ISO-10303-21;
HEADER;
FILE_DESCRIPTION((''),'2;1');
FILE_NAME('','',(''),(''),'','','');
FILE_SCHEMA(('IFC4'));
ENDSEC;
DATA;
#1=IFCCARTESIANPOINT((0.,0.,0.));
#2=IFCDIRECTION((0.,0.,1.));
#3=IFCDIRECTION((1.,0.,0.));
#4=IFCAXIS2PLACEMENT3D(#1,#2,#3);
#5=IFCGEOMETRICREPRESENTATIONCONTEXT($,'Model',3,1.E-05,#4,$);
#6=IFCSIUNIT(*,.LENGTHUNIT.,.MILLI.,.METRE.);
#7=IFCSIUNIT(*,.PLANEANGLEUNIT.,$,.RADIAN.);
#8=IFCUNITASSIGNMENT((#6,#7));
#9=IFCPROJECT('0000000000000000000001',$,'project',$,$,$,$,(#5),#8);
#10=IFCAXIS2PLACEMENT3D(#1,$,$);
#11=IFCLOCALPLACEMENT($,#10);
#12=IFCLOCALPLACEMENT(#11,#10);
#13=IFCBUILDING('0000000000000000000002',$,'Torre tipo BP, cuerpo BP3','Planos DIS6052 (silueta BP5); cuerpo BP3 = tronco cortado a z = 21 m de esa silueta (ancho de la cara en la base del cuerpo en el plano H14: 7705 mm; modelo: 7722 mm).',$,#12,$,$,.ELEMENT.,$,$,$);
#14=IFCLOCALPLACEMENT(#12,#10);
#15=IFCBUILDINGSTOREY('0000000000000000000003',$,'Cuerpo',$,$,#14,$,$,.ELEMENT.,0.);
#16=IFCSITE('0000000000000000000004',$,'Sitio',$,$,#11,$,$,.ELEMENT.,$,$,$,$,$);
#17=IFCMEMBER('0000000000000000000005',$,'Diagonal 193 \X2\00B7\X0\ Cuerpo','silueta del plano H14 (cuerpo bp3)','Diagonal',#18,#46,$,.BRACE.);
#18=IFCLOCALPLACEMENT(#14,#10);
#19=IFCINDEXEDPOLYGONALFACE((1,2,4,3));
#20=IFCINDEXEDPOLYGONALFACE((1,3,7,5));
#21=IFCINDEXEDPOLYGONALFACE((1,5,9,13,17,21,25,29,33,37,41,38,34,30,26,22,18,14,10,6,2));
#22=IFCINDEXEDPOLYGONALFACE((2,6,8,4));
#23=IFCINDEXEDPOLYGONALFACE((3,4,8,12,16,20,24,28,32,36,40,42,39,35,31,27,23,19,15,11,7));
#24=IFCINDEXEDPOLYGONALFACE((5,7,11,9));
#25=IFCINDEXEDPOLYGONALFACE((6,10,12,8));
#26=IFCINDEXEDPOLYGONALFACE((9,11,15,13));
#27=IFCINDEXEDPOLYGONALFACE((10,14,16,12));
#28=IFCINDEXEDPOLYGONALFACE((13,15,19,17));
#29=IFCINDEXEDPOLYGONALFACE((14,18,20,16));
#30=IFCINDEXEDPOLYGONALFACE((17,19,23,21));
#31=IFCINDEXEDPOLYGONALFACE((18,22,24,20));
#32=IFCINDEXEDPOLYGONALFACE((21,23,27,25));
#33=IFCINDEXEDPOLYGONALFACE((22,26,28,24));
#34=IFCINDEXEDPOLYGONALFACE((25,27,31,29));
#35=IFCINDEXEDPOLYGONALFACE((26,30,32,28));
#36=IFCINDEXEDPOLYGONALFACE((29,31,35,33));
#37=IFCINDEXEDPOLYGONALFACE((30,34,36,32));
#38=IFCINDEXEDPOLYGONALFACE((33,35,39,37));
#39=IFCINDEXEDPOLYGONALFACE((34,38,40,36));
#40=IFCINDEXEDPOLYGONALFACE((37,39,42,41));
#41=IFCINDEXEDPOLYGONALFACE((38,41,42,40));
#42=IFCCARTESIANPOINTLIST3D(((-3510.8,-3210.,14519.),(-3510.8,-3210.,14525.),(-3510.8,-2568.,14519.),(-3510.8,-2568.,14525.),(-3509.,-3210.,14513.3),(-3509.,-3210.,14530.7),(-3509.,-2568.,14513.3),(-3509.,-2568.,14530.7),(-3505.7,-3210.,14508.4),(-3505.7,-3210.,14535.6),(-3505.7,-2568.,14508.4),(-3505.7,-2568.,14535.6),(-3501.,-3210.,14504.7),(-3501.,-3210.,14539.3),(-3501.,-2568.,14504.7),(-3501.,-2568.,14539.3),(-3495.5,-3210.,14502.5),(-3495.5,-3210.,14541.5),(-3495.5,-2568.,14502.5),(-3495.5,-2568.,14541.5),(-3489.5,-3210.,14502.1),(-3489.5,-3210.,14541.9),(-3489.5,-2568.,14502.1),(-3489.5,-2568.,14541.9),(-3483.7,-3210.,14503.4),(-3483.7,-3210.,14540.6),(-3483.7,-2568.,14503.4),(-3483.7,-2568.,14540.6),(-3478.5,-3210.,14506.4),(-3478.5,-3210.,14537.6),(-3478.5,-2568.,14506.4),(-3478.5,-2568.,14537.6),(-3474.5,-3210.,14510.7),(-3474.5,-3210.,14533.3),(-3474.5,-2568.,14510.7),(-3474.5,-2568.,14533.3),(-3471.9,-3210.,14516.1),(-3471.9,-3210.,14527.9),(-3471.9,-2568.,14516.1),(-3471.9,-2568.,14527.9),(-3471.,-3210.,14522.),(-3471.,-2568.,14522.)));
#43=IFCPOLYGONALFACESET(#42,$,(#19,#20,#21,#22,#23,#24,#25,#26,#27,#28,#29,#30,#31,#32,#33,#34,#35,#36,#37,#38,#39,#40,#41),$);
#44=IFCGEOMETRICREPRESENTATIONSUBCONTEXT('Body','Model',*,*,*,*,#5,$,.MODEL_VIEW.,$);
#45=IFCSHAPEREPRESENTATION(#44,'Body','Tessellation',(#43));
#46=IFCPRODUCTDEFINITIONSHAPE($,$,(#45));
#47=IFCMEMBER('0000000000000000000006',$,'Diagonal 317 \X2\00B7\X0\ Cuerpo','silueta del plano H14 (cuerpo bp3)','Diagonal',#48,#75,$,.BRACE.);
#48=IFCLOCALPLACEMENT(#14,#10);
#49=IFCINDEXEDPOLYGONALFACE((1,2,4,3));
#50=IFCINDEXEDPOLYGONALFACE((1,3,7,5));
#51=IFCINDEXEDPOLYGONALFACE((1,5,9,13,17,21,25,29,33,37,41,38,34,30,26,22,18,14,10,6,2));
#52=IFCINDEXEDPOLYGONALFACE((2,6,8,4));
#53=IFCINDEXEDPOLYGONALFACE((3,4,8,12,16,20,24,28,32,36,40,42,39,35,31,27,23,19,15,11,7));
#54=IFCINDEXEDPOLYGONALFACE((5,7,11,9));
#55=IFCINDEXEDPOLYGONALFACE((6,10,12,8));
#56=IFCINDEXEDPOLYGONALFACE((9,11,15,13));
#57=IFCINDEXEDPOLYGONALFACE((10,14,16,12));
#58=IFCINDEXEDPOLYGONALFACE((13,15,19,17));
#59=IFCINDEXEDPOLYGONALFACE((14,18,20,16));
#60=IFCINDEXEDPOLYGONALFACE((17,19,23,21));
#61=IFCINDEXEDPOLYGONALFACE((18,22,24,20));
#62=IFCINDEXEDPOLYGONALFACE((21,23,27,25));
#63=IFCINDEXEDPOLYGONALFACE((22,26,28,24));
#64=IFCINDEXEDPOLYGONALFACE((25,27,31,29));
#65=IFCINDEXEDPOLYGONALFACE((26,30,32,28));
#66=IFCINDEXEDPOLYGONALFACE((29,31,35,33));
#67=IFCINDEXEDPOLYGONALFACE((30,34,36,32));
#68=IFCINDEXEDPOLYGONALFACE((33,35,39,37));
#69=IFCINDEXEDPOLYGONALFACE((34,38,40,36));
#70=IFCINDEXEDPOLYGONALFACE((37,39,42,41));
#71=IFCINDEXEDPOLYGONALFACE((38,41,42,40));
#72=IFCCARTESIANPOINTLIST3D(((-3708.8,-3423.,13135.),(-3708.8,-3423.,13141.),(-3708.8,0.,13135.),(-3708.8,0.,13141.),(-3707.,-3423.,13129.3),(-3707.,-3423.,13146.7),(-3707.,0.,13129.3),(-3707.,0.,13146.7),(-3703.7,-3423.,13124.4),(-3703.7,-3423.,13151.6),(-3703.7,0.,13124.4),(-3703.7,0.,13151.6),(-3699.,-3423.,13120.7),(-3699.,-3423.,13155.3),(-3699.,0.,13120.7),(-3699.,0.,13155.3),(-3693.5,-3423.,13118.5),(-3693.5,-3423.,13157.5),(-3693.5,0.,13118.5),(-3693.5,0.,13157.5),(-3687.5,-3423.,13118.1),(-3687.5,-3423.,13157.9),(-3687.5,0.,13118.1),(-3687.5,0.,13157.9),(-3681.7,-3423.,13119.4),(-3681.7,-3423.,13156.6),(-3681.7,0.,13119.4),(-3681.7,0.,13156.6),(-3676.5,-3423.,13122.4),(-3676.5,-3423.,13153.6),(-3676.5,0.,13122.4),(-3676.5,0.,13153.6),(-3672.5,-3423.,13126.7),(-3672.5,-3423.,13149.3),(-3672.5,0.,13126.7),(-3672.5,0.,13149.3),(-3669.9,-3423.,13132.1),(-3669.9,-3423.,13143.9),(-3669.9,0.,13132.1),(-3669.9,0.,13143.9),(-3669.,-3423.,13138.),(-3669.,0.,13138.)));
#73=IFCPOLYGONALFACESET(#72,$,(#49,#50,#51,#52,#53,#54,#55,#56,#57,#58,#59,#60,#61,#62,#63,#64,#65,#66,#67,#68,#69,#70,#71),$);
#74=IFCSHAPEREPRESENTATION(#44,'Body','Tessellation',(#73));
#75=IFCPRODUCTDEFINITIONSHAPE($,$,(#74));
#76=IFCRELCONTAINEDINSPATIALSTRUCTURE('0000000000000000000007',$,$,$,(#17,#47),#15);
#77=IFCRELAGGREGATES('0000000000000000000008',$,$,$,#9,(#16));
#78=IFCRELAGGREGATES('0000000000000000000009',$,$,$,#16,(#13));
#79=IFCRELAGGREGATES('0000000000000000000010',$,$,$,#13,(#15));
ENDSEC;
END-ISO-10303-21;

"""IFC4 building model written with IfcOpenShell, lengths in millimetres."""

from ifc_helpers import new_model, si_unit, frame, origin, origin_with_axes, place, context, subcontext, project, spatial, circle, extrude, element, save


model = new_model("IFC4")

# Units and contexts
model_context = context("Model", 3, precision=1e-05, world=origin_with_axes())
body_context = subcontext(model_context, "Body", "Model", "MODEL_VIEW")
ifc_project = project(units=[si_unit("LENGTHUNIT", "METRE", prefix="MILLI"), si_unit("PLANEANGLEUNIT", "RADIAN")], contexts=[model_context])

# Site, building, storey
site_placement = place(None, origin())
site = spatial("IfcSite", under=ifc_project, at=site_placement, Name="Sitio", CompositionType="ELEMENT")
building_placement = place(site_placement, origin())
building = spatial("IfcBuilding", under=site, at=building_placement, Name="Torre tipo BP, cuerpo BP3", Description="Planos DIS6052 (silueta BP5); cuerpo BP3 = tronco cortado a z = 21 m de esa silueta (ancho de la cara en la base del cuerpo en el plano H14: 7705 mm; modelo: 7722 mm).", CompositionType="ELEMENT")
storey_placement = place(building_placement, origin())
storey = spatial("IfcBuildingStorey", under=building, at=storey_placement, Name="Cuerpo", CompositionType="ELEMENT", Elevation=0.0)

# Members
member_1_placement = place(storey_placement, frame((-3491.0, -2568.0, 14522.0), z_axis=(0.0, -1.0, 0.0), x_axis=(1.0, 0.0, 0.0)))
element("IfcMember", 1, at=member_1_placement, inside=storey, Name="Diagonal 193 · Cuerpo", Description="silueta del plano H14 (cuerpo bp3)", ObjectType="Diagonal", PredefinedType="BRACE", context=body_context, shape_type="SweptSolid", body=[
    extrude(circle(Radius=20.0), None, (0.0, 0.0, 1.0), 642.0),
])
member_2_placement = place(storey_placement, frame((-3689.0, -3423.0, 13138.0), z_axis=(0.0, 1.0, 0.0), x_axis=(1.0, 0.0, 0.0)))
element("IfcMember", 2, at=member_2_placement, inside=storey, Name="Diagonal 317 · Cuerpo", Description="silueta del plano H14 (cuerpo bp3)", ObjectType="Diagonal", PredefinedType="BRACE", context=body_context, shape_type="SweptSolid", body=[
    extrude(circle(Radius=20.0), None, (0.0, 0.0, 1.0), 3423.0),
])

save(model, "model.ifc")
